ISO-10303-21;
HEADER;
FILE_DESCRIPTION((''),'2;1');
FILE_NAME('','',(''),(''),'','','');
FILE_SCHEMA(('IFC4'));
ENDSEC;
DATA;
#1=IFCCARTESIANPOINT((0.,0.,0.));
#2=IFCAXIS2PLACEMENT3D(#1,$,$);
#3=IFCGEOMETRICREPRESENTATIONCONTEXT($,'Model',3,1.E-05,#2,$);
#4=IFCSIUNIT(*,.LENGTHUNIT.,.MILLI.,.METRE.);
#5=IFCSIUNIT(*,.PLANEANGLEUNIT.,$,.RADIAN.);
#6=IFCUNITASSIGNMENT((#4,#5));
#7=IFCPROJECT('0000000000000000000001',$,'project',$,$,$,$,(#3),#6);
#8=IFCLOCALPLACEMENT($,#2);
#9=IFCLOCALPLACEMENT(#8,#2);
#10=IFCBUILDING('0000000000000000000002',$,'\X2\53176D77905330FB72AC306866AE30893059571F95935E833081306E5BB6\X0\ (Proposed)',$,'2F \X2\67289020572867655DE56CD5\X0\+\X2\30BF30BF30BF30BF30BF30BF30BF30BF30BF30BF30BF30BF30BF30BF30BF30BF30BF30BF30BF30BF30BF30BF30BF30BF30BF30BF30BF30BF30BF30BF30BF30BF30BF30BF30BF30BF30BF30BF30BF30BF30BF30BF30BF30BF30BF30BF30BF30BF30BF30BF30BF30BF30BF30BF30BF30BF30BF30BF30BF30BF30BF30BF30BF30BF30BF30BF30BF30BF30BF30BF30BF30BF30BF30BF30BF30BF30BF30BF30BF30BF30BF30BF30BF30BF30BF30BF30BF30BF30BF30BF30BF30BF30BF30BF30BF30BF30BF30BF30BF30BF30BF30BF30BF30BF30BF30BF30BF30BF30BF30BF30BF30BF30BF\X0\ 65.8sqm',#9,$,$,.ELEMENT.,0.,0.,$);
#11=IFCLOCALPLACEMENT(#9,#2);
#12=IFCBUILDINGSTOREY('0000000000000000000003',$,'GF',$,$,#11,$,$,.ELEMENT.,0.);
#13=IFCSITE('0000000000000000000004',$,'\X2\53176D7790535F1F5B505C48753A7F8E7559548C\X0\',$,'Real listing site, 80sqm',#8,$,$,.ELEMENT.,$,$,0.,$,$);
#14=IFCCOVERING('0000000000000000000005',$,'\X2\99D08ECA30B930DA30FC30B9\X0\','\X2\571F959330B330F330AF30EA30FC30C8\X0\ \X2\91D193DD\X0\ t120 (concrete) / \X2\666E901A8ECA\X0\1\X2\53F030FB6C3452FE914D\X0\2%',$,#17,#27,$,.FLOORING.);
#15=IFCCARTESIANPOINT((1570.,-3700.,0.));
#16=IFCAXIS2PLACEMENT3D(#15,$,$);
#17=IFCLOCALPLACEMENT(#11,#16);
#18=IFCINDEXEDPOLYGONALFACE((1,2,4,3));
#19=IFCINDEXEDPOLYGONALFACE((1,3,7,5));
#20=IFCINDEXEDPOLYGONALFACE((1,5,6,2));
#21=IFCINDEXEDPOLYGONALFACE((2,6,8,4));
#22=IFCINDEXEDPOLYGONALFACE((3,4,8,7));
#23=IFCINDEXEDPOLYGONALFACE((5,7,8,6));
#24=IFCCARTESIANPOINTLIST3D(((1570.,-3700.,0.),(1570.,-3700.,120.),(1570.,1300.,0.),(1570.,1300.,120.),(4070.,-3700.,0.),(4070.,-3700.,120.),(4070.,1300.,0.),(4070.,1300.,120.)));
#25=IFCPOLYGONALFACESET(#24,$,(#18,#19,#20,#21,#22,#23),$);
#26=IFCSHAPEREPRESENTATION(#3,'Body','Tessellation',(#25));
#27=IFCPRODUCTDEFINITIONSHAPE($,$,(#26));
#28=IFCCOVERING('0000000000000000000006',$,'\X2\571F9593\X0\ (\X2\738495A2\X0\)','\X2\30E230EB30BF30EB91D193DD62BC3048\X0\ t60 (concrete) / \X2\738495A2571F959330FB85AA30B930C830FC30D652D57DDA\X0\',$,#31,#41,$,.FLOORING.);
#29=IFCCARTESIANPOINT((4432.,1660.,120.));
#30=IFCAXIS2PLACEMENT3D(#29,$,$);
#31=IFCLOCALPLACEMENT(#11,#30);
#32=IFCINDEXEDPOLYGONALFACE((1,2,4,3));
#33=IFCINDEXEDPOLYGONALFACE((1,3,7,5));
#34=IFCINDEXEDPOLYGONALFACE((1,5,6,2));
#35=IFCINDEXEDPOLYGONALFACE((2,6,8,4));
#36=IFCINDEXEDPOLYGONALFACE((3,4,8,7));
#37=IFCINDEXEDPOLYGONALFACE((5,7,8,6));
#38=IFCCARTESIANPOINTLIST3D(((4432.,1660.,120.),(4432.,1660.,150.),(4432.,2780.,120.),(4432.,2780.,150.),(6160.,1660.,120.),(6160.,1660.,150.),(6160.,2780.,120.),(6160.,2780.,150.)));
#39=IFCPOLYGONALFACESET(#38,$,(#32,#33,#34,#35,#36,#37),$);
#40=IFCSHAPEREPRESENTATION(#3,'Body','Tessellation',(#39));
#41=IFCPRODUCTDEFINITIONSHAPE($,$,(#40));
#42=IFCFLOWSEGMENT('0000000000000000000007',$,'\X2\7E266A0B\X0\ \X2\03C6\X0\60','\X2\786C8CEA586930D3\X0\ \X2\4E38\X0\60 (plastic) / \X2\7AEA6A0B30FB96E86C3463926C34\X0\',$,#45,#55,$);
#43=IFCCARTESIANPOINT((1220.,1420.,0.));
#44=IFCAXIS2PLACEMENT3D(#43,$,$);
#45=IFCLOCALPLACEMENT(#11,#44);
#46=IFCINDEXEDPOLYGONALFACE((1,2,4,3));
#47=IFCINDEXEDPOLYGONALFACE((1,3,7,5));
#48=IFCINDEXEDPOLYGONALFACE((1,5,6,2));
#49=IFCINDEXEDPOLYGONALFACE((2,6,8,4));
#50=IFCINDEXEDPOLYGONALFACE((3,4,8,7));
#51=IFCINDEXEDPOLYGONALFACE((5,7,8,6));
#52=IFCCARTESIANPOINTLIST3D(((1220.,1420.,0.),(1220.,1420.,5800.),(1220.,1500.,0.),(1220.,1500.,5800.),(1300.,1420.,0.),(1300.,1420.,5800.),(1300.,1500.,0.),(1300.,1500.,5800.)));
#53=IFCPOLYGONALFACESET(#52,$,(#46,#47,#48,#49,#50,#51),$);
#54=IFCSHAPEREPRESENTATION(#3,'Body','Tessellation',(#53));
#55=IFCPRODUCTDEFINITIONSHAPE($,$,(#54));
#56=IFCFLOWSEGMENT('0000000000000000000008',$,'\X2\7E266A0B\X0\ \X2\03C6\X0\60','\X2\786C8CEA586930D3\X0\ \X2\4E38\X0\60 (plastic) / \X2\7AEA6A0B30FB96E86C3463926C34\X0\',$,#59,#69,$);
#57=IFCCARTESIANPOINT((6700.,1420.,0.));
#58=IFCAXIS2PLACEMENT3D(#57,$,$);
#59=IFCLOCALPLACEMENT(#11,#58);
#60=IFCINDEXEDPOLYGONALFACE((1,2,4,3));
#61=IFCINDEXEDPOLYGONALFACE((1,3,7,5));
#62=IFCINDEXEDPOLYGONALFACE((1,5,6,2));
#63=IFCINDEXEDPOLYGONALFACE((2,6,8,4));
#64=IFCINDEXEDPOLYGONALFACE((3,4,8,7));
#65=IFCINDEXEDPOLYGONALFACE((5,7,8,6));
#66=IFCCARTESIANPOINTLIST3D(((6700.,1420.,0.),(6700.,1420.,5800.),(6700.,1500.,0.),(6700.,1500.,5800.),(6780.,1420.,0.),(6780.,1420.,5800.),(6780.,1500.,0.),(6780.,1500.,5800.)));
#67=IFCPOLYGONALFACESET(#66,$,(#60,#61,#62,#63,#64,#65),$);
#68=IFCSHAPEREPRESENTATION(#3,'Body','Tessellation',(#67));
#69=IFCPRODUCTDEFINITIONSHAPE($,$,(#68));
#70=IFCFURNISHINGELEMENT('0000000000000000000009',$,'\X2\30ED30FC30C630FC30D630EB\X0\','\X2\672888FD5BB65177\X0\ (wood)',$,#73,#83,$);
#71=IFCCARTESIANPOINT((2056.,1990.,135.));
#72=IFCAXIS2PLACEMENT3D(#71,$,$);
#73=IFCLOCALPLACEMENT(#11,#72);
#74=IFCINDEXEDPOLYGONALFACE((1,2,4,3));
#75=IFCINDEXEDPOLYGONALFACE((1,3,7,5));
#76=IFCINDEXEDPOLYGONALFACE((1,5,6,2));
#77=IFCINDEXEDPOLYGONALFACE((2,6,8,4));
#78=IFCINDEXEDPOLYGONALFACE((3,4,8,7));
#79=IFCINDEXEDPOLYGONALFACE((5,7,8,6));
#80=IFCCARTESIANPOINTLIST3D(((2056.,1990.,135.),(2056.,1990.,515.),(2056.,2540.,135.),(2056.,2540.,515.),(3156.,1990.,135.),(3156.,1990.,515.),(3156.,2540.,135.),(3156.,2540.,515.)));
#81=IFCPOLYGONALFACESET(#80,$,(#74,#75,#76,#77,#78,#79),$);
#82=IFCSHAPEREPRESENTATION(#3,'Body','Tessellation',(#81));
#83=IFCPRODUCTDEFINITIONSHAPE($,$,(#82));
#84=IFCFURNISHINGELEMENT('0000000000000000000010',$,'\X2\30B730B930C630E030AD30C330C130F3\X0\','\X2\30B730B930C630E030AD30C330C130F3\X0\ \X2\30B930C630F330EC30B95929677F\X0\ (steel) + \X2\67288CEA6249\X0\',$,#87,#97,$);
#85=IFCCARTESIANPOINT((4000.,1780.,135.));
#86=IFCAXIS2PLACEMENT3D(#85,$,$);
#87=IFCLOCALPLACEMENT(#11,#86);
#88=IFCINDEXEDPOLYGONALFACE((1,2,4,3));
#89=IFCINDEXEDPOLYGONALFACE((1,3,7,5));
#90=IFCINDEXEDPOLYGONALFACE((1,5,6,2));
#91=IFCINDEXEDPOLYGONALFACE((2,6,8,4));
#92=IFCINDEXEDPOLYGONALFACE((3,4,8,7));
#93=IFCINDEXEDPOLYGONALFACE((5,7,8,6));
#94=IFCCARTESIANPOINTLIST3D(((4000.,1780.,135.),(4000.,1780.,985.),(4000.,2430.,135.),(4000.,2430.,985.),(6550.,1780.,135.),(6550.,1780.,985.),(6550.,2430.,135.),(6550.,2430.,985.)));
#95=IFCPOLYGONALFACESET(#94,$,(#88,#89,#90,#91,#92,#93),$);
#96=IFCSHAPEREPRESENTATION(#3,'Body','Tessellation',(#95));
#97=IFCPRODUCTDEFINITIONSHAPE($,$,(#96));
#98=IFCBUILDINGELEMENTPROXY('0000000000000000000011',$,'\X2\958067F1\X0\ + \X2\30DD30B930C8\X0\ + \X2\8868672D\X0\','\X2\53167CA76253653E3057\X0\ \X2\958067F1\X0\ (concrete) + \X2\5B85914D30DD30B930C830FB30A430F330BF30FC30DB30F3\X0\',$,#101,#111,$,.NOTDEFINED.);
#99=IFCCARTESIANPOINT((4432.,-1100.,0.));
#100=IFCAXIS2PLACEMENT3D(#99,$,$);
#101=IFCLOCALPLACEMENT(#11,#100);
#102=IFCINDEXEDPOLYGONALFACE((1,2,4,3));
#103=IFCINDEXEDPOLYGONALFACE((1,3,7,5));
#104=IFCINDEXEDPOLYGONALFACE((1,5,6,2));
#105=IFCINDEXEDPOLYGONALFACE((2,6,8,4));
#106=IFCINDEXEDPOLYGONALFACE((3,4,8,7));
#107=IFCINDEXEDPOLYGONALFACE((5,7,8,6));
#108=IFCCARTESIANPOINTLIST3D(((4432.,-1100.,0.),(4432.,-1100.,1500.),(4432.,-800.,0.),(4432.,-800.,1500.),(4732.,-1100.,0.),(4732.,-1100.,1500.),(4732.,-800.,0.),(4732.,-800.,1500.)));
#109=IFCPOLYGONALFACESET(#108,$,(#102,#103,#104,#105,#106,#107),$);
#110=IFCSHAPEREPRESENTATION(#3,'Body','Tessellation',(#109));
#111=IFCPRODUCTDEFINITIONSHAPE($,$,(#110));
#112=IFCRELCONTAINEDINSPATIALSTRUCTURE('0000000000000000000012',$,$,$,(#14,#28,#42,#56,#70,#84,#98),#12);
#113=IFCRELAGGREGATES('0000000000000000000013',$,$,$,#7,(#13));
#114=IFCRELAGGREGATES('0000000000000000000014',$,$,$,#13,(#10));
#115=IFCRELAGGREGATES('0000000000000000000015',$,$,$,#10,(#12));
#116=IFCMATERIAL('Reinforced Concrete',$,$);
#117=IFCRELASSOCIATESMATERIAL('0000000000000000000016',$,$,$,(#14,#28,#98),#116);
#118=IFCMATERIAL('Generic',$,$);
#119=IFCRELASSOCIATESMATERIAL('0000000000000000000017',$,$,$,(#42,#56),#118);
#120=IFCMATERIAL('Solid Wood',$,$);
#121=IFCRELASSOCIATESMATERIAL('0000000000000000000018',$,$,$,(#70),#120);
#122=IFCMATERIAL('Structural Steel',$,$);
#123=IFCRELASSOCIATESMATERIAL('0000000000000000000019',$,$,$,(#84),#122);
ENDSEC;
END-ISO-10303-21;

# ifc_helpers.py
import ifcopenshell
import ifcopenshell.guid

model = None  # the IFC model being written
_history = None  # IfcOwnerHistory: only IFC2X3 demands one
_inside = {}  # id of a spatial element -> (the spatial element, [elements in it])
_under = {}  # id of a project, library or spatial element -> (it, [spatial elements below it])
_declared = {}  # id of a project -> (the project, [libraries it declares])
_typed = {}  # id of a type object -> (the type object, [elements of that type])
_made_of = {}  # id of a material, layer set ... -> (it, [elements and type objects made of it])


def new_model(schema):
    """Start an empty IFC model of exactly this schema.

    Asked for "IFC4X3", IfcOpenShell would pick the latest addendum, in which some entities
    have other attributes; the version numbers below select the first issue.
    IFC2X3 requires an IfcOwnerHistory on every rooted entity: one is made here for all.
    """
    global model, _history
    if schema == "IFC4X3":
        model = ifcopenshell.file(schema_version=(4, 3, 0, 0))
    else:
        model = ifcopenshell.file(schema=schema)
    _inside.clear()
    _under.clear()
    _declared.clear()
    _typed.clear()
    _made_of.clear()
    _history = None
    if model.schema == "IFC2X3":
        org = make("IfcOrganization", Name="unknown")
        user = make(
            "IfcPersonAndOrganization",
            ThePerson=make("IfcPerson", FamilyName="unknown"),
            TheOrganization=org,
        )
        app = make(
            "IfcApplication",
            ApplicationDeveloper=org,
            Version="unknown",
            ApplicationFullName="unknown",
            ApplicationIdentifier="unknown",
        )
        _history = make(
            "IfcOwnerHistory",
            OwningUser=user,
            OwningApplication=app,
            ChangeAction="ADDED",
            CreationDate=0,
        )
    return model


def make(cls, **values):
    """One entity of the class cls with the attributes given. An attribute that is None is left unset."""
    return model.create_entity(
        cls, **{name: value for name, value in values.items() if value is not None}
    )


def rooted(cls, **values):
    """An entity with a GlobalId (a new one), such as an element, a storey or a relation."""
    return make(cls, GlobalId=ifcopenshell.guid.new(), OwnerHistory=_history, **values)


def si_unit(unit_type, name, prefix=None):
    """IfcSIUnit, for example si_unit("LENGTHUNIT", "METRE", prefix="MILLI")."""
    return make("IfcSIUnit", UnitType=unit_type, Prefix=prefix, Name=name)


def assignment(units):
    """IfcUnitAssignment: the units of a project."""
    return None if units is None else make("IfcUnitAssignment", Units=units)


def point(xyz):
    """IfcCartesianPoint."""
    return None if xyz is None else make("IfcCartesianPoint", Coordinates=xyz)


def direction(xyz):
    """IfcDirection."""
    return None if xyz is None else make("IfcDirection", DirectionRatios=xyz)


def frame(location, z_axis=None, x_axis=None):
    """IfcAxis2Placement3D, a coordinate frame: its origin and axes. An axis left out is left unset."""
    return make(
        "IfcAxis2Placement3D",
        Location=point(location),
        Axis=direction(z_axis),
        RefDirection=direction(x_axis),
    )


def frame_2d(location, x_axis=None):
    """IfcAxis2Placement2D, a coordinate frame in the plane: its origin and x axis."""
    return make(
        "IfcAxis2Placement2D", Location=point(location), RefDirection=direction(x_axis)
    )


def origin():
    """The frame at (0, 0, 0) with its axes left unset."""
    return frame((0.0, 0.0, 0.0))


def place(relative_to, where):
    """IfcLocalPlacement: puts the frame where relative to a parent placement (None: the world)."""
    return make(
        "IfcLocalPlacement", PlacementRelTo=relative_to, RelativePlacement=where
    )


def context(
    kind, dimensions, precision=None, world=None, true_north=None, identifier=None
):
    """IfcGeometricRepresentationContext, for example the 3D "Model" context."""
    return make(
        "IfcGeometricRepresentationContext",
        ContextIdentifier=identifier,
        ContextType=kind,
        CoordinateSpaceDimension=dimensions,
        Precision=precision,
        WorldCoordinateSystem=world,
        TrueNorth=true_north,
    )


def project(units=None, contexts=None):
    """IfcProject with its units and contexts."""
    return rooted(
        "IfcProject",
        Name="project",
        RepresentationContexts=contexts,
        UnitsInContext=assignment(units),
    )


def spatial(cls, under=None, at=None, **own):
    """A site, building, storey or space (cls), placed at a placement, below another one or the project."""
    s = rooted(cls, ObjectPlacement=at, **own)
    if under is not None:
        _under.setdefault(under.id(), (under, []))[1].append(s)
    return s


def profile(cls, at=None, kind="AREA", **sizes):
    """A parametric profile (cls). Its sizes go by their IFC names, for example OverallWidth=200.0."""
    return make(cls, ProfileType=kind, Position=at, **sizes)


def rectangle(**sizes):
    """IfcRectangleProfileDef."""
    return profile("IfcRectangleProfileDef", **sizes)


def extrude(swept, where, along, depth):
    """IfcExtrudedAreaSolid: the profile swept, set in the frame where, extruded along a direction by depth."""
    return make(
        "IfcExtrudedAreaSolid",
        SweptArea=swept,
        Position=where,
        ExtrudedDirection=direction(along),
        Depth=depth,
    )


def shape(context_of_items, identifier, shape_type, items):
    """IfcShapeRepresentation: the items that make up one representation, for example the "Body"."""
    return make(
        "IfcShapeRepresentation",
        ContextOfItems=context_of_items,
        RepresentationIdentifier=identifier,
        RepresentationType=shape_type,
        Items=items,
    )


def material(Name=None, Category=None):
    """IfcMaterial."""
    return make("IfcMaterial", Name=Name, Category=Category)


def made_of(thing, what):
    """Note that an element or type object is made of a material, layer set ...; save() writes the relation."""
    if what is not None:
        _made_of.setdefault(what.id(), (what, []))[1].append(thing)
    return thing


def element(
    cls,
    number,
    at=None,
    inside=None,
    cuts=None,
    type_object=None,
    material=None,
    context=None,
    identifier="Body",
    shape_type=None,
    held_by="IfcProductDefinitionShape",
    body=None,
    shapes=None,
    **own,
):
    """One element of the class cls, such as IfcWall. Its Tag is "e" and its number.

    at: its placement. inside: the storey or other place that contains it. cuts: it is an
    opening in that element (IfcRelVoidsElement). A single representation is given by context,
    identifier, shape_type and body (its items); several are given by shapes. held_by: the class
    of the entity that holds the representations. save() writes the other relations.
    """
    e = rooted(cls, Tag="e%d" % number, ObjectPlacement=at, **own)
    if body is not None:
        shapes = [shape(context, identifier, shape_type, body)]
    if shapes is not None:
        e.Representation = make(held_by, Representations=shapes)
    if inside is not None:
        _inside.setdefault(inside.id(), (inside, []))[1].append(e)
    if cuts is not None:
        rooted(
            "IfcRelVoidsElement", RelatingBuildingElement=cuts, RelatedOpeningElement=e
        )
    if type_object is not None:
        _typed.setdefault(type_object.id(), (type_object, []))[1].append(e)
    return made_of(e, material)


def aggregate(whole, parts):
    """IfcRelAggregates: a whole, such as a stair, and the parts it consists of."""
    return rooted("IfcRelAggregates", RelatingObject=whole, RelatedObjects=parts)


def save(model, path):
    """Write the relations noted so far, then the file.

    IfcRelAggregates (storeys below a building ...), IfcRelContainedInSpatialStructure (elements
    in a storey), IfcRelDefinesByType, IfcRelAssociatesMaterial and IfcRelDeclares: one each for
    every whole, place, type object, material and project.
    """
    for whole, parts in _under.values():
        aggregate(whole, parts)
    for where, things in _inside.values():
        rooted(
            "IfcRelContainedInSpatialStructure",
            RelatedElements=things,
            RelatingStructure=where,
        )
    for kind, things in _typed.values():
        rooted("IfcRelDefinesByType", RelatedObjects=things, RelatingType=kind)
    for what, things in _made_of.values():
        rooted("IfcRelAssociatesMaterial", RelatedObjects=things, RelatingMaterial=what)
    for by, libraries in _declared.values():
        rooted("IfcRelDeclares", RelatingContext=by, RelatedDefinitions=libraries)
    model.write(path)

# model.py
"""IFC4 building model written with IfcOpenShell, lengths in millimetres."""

from ifc_helpers import new_model, si_unit, frame, frame_2d, origin, place, context, project, spatial, rectangle, extrude, material, element, save


model = new_model("IFC4")

# Units and contexts
model_context = context("Model", 3, precision=1e-05, world=origin())
ifc_project = project(units=[si_unit("LENGTHUNIT", "METRE", prefix="MILLI"), si_unit("PLANEANGLEUNIT", "RADIAN")], contexts=[model_context])

# Site, building, storey
site_placement = place(None, origin())
site = spatial("IfcSite", under=ifc_project, at=site_placement, Name="北海道弟子屈町美留和", ObjectType="Real listing site, 80sqm", CompositionType="ELEMENT", RefElevation=0.0)
building_placement = place(site_placement, origin())
building = spatial("IfcBuilding", under=site, at=building_placement, Name="北海道・犬と暮らす土間広めの家 (Proposed)", ObjectType="2F 木造在来工法+タタタタタタタタタタタタタタタタタタタタタタタタタタタタタタタタタタタタタタタタタタタタタタタタタタタタタタタタタタタタタタタタタタタタタタタタタタタタタタタタタタタタタタタタタタタタタタタタタタタタタタタタタタタタタタタタタ 65.8sqm", CompositionType="ELEMENT", ElevationOfRefHeight=0.0, ElevationOfTerrain=0.0)
storey_placement = place(building_placement, origin())
storey = spatial("IfcBuildingStorey", under=building, at=storey_placement, Name="GF", CompositionType="ELEMENT", Elevation=0.0)

# Shared definitions
ifc_material_1 = material(Name="Solid Wood")

# Shared definitions
ifc_material_2 = material(Name="Reinforced Concrete")

# Coverings
ifc_material_3 = material(Name="Generic")
covering_1_placement = place(storey_placement, frame((1570.0, -3700.0, 0.0)))
element("IfcCovering", 1, at=covering_1_placement, inside=storey, material=ifc_material_2, Name="駐車スペース", Description="土間コンクリート 金鏝 t120 (concrete) / 普通車1台・水勾配2%", PredefinedType="FLOORING", context=model_context, shape_type="SweptSolid", body=[
    extrude(rectangle(XDim=2500.0, YDim=5000.0, at=frame_2d((1250.0, 2500.0))), frame((1570.0, -3700.0, 0.0)), (0.0, 0.0, 1.0), 120.0),
])
covering_2_placement = place(storey_placement, frame((4432.0, 1660.0, 120.0)))
element("IfcCovering", 2, at=covering_2_placement, inside=storey, material=ifc_material_2, Name="土間 (玄関)", Description="モルタル金鏝押え t60 (concrete) / 玄関土間・薪ストーブ動線", PredefinedType="FLOORING", context=model_context, shape_type="SweptSolid", body=[
    extrude(rectangle(XDim=1728.0, YDim=1120.0, at=frame_2d((864.0, 560.0))), frame((4432.0, 1660.0, 120.0)), (0.0, 0.0, 1.0), 30.0),
])

# Flow segments
flow_segment_1_placement = place(storey_placement, frame((1220.0, 1420.0, 0.0)))
element("IfcFlowSegment", 3, at=flow_segment_1_placement, inside=storey, material=ifc_material_3, Name="縦樋 φ60", Description="硬質塩ビ 丸60 (plastic) / 竪樋・雨水排水", context=model_context, shape_type="SweptSolid", body=[
    extrude(rectangle(XDim=80.0, YDim=80.0, at=frame_2d((40.0, 40.0))), frame((1220.0, 1420.0, 0.0)), (0.0, 0.0, 1.0), 5800.0),
])
flow_segment_2_placement = place(storey_placement, frame((6700.0, 1420.0, 0.0)))
element("IfcFlowSegment", 4, at=flow_segment_2_placement, inside=storey, material=ifc_material_3, Name="縦樋 φ60", Description="硬質塩ビ 丸60 (plastic) / 竪樋・雨水排水", context=model_context, shape_type="SweptSolid", body=[
    extrude(rectangle(XDim=80.0, YDim=80.0, at=frame_2d((40.0, 40.0))), frame((6700.0, 1420.0, 0.0)), (0.0, 0.0, 1.0), 5800.0),
])

# Furnishing elements
furnishing_1_placement = place(storey_placement, frame((2056.0, 1990.0, 135.0)))
element("IfcFurnishingElement", 5, at=furnishing_1_placement, inside=storey, material=ifc_material_1, Name="ローテーブル", Description="木製家具 (wood)", context=model_context, shape_type="SweptSolid", body=[
    extrude(rectangle(XDim=1100.0, YDim=550.0, at=frame_2d((550.0, 275.0))), frame((2056.0, 1990.0, 135.0)), (0.0, 0.0, 1.0), 380.0),
])
ifc_material_4 = material(Name="Structural Steel")
furnishing_2_placement = place(storey_placement, frame((4000.0, 1780.0, 135.0)))
element("IfcFurnishingElement", 6, at=furnishing_2_placement, inside=storey, material=ifc_material_4, Name="システムキッチン", Description="システムキッチン ステンレス天板 (steel) + 木質扉", context=model_context, shape_type="SweptSolid", body=[
    extrude(rectangle(XDim=2550.0, YDim=650.0, at=frame_2d((1275.0, 325.0))), frame((4000.0, 1780.0, 135.0)), (0.0, 0.0, 1.0), 850.0),
])

# Building element proxy
proxy_placement = place(storey_placement, frame((4432.0, -1100.0, 0.0)))
element("IfcBuildingElementProxy", 7, at=proxy_placement, inside=storey, material=ifc_material_2, Name="門柱 + ポスト + 表札", Description="化粧打放し 門柱 (concrete) + 宅配ポスト・インターホン", PredefinedType="NOTDEFINED", context=model_context, shape_type="SweptSolid", body=[
    extrude(rectangle(XDim=300.0, YDim=300.0, at=frame_2d((150.0, 150.0))), frame((4432.0, -1100.0, 0.0)), (0.0, 0.0, 1.0), 1500.0),
])

save(model, "model.ifc")
